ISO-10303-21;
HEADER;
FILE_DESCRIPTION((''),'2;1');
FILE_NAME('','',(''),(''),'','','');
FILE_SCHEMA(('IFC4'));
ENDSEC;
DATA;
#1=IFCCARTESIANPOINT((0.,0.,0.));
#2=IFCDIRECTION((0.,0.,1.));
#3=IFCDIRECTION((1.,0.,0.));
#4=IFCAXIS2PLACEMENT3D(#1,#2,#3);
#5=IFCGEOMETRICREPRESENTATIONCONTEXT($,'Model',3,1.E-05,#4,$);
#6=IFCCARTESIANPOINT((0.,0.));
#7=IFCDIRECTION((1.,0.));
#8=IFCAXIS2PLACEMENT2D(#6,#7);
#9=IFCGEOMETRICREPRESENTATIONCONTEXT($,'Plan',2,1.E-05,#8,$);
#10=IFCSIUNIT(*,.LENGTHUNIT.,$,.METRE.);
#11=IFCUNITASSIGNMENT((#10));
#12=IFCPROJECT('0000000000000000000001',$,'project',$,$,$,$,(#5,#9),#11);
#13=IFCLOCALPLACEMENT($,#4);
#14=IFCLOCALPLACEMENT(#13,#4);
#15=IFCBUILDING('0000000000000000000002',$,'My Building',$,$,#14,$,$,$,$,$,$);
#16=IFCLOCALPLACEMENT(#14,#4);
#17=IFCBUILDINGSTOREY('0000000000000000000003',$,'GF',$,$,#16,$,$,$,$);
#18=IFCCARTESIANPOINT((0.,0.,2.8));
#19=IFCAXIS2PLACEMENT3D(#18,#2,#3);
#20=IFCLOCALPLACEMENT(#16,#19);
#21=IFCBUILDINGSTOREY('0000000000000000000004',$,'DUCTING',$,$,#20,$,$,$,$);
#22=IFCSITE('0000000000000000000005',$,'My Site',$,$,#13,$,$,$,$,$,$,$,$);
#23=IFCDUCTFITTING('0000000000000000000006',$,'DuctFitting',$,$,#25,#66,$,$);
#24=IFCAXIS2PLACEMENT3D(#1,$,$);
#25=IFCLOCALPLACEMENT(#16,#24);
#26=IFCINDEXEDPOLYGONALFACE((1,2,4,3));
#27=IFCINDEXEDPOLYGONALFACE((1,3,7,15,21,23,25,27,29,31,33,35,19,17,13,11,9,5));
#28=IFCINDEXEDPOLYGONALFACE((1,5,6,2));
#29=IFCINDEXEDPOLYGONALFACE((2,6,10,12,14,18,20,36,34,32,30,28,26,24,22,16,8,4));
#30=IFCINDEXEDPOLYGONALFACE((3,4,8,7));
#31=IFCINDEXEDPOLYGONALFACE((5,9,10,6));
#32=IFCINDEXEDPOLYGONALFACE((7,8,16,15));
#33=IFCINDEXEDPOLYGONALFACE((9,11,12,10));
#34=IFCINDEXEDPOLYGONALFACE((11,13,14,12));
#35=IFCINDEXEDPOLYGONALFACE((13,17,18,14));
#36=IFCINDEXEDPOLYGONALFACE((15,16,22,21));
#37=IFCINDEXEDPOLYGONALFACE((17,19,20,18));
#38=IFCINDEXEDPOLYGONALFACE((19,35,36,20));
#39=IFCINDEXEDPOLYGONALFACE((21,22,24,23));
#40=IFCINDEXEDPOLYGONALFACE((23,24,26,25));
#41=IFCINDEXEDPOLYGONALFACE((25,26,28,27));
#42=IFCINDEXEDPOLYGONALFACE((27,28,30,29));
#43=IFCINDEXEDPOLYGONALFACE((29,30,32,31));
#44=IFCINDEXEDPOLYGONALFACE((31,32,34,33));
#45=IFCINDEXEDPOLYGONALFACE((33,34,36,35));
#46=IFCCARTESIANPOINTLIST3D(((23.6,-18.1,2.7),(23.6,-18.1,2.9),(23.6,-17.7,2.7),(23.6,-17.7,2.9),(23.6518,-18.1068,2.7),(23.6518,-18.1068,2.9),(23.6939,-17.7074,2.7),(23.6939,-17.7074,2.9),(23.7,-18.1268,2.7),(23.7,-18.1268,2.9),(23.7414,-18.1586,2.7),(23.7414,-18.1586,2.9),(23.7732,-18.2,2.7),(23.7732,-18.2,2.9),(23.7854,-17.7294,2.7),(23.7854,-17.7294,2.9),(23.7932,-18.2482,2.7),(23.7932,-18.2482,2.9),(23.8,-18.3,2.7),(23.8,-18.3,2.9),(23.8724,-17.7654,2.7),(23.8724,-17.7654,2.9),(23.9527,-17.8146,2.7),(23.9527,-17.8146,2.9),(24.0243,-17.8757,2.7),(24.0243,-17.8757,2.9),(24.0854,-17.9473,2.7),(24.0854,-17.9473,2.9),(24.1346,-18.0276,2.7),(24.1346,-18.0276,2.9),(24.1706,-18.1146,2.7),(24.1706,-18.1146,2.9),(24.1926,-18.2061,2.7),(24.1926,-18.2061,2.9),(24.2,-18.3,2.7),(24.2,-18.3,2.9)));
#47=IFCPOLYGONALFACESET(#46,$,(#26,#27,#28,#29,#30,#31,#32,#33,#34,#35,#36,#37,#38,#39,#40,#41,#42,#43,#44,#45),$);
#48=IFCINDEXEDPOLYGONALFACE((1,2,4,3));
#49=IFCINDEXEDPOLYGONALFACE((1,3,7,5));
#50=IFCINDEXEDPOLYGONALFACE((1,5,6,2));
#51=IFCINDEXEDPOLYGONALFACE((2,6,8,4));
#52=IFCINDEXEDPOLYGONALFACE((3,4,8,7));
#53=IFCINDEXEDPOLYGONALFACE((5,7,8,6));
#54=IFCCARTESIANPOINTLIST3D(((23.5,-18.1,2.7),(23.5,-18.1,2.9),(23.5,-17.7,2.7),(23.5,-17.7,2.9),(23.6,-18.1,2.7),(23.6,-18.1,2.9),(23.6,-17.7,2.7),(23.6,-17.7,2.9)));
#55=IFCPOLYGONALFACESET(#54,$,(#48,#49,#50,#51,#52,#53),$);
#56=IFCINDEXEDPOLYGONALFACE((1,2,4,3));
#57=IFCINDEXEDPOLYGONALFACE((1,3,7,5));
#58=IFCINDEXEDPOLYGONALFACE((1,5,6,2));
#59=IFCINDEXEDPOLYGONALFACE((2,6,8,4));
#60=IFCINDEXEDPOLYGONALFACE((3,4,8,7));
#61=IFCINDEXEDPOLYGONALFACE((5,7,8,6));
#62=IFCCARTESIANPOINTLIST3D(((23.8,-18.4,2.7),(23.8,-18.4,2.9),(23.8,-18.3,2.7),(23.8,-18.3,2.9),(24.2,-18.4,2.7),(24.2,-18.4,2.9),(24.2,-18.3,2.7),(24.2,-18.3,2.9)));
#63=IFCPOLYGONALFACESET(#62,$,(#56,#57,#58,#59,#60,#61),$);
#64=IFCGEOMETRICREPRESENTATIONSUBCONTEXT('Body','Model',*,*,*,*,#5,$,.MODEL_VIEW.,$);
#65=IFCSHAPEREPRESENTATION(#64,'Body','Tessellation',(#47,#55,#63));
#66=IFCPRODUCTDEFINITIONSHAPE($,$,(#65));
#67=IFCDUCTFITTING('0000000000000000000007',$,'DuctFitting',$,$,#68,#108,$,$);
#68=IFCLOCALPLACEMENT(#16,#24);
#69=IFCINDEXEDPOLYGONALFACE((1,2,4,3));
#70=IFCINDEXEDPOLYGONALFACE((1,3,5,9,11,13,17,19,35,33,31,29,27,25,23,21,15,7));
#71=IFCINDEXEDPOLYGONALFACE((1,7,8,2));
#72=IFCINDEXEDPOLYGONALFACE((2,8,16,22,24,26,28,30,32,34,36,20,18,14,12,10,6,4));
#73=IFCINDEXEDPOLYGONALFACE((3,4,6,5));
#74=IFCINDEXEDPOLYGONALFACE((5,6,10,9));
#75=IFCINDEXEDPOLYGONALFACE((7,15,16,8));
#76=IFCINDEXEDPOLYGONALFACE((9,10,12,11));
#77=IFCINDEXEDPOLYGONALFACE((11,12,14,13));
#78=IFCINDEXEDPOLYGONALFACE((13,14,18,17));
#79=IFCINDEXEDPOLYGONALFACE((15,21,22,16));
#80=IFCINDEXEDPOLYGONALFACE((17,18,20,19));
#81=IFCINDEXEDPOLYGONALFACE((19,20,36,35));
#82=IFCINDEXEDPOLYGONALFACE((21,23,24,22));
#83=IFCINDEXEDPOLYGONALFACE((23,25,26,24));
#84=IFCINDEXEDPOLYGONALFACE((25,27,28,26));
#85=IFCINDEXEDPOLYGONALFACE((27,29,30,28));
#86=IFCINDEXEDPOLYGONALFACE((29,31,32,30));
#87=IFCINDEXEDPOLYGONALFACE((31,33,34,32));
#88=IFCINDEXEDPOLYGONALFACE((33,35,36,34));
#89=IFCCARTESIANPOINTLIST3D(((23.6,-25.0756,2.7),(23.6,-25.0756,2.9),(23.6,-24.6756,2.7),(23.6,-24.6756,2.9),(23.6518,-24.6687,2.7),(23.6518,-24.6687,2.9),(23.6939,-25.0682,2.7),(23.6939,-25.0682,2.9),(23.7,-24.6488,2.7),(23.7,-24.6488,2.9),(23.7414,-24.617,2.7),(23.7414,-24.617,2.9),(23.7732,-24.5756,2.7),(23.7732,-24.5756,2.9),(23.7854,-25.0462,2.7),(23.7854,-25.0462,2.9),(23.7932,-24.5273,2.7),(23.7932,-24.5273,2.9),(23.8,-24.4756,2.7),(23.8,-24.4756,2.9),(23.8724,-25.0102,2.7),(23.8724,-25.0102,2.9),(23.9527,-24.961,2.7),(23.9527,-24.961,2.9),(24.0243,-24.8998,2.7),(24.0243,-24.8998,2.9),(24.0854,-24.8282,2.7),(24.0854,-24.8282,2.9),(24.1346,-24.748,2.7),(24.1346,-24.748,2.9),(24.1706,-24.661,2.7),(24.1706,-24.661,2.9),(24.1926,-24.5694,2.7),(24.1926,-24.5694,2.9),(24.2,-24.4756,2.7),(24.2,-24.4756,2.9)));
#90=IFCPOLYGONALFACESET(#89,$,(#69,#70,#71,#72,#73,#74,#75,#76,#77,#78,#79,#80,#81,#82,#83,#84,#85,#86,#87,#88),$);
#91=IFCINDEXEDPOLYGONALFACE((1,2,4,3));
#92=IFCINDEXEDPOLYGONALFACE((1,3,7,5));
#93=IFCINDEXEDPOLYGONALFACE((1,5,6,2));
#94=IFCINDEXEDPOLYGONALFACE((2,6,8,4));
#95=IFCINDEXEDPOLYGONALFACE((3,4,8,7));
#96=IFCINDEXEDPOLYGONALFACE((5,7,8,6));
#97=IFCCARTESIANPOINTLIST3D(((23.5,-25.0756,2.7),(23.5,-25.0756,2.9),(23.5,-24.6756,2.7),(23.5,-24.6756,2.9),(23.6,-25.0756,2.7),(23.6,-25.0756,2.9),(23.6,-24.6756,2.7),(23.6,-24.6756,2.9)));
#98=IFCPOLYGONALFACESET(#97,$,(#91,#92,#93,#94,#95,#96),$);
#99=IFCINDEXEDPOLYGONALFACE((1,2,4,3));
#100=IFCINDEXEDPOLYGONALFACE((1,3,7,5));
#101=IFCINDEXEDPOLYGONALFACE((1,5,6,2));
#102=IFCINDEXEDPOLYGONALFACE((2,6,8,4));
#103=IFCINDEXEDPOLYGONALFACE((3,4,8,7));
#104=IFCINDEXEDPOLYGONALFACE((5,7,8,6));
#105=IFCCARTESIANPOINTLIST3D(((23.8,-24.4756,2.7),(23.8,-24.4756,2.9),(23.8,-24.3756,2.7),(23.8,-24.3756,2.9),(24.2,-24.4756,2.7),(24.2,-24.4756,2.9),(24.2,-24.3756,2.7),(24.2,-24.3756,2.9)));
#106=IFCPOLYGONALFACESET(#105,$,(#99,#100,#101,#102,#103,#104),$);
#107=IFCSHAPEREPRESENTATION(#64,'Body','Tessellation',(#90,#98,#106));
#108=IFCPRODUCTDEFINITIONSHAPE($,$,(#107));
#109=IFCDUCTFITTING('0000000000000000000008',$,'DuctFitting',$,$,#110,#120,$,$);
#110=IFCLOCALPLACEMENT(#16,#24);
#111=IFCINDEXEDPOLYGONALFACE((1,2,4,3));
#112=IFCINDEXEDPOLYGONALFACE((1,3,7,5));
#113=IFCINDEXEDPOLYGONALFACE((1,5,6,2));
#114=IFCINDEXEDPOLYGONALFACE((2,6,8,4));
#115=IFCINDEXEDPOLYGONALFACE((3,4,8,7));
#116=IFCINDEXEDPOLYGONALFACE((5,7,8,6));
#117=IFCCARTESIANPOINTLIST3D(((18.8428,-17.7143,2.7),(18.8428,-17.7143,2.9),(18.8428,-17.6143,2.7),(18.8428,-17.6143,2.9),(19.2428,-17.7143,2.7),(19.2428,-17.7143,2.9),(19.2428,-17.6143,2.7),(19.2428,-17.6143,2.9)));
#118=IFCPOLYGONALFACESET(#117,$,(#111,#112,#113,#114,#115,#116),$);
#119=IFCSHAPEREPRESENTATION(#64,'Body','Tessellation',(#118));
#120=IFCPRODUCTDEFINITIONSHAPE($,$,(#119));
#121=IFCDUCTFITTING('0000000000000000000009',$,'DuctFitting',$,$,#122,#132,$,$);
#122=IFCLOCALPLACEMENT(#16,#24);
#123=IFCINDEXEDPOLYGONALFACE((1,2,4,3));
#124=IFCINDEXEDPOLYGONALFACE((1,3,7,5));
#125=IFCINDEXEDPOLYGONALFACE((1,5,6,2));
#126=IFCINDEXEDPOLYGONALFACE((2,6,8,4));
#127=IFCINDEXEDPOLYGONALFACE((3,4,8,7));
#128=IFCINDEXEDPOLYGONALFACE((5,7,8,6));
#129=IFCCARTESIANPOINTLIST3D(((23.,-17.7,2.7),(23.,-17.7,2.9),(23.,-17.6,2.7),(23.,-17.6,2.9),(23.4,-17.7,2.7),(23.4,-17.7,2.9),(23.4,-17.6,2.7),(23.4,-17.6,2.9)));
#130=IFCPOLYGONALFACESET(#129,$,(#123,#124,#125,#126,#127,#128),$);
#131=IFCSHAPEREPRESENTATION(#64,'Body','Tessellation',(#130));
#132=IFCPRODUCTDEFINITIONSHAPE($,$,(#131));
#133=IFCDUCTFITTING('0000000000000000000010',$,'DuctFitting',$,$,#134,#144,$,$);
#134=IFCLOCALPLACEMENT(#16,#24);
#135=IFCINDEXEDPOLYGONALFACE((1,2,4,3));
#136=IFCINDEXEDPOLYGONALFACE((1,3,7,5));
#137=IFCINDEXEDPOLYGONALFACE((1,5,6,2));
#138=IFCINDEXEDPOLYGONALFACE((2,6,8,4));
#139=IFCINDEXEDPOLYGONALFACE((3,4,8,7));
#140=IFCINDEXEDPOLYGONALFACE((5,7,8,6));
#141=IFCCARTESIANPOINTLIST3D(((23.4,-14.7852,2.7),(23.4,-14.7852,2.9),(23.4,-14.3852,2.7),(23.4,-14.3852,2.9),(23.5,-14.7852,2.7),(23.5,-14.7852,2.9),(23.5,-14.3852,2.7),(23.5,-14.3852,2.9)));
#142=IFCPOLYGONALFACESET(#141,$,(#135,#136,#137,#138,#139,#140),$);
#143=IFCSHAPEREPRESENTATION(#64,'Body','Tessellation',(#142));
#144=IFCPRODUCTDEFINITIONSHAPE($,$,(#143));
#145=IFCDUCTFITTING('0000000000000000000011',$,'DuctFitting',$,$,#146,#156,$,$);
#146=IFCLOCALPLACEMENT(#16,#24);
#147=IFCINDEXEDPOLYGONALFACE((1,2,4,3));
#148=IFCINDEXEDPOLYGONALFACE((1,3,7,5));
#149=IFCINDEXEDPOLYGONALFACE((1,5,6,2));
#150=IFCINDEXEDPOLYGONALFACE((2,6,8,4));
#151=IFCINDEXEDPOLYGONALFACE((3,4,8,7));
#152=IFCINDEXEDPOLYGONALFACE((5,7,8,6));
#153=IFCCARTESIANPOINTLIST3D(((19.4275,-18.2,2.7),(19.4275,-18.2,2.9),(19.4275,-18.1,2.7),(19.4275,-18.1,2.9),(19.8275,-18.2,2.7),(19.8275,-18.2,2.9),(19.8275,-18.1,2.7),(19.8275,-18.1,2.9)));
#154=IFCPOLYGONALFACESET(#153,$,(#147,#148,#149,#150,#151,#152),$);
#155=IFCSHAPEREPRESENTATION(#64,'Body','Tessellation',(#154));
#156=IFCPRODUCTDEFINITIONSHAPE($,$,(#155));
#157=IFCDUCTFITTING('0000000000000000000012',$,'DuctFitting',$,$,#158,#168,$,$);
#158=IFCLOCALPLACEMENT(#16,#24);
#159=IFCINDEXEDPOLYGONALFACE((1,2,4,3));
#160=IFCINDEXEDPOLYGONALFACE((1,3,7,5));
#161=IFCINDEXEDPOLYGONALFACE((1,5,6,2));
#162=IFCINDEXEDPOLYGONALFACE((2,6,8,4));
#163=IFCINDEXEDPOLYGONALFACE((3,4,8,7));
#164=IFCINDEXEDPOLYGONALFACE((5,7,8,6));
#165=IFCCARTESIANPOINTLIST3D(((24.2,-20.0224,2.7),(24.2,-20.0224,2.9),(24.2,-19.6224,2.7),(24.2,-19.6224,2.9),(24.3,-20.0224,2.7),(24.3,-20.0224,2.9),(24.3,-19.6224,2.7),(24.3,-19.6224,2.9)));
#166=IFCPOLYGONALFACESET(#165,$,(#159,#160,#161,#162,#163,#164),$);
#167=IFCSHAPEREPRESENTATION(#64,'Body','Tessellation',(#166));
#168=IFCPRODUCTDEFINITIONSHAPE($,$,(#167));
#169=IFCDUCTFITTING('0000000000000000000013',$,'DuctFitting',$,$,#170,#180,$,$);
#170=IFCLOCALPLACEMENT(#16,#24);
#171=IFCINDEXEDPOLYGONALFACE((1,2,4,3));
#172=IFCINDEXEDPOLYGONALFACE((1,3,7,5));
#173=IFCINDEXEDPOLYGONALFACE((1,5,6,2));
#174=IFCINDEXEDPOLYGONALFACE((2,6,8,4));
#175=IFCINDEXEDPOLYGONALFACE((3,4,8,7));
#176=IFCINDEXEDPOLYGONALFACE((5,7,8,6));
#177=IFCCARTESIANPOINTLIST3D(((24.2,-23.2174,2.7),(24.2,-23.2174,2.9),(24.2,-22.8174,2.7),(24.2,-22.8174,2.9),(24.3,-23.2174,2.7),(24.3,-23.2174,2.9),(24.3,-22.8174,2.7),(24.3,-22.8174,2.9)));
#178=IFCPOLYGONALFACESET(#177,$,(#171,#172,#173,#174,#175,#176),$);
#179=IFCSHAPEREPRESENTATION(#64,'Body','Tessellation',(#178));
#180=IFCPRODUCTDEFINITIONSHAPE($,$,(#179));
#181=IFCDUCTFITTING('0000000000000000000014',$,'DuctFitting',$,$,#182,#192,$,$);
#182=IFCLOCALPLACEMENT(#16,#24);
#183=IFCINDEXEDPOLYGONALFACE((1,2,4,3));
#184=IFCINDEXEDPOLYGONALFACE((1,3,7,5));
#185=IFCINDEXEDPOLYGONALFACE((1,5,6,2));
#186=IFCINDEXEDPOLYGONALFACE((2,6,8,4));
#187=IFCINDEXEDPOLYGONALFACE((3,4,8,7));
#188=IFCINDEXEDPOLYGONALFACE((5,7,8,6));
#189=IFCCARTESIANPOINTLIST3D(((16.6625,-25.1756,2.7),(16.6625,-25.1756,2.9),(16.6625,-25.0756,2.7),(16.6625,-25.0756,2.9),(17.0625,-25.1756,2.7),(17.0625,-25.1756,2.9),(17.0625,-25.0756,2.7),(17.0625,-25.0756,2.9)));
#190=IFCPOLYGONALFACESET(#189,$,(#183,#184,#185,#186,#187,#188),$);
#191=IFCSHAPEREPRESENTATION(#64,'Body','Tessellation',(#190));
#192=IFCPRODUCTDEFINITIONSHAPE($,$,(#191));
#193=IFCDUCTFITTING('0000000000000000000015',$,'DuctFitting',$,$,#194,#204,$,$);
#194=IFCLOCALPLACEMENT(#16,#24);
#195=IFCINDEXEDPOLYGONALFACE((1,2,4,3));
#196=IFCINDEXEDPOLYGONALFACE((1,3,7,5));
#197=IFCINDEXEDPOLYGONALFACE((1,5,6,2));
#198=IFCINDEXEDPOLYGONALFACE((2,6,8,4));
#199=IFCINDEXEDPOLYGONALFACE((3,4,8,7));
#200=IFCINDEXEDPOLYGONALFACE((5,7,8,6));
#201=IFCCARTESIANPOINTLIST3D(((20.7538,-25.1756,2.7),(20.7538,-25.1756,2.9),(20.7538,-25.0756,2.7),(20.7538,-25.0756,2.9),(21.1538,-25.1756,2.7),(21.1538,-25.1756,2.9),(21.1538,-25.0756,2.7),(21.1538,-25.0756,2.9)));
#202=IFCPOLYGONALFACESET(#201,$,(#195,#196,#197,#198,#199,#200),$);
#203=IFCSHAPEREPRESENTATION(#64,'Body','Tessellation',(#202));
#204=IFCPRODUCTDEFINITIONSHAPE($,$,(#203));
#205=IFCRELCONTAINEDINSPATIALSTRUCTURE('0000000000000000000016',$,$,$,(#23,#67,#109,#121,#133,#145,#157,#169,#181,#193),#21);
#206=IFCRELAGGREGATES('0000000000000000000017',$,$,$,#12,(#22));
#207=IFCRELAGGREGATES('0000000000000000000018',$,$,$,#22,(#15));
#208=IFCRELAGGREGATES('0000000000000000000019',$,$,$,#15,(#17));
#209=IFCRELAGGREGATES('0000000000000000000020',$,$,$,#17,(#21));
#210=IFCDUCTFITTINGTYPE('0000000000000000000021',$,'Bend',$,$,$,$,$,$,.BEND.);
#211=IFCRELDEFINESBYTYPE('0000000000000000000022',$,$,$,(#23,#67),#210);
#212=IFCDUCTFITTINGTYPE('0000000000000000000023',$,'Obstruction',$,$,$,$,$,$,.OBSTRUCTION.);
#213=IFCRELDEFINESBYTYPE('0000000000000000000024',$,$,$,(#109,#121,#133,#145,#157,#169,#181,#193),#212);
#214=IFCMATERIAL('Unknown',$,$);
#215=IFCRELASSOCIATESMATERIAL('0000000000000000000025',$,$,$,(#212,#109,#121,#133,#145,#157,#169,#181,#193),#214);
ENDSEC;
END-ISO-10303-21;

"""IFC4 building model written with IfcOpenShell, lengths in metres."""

from ifc_helpers import new_model, si_unit, frame, origin_with_axes, origin_2d_with_axis, place, context, subcontext, project, spatial, line, arc, indexed_curve, rectangle, outline, extrude, source, transform, mapped, material, material_profile, profile_set, profile_usage, type_object, type_shapes, element, save


model = new_model("IFC4")

# Units and contexts
model_context = context("Model", 3, precision=1e-05, world=origin_with_axes())
plan_context = context("Plan", 2, precision=1e-05, world=origin_2d_with_axis())
body_context = subcontext(model_context, "Body", "Model", "MODEL_VIEW")
ifc_project = project(units=[si_unit("LENGTHUNIT", "METRE")], contexts=[model_context, plan_context])

# Site, building, storeys
site_placement = place(None, origin_with_axes())
site = spatial("IfcSite", under=ifc_project, at=site_placement, Name="My Site")
building_placement = place(site_placement, origin_with_axes())
building = spatial("IfcBuilding", under=site, at=building_placement, Name="My Building")
storey_1_placement = place(building_placement, origin_with_axes())
storey_1 = spatial("IfcBuildingStorey", under=building, at=storey_1_placement, Name="GF")
storey_2_placement = place(storey_1_placement, frame((0.0, 0.0, 2.8), z_axis=(0.0, 0.0, 1.0), x_axis=(1.0, 0.0, 0.0)))
storey_2 = spatial("IfcBuildingStorey", under=storey_1, at=storey_2_placement, Name="DUCTING")

# Shared definitions
ifc_material = material(Name="Unknown")

# Duct fittings
duct_fitting_type_1 = type_object("IfcDuctFittingType", Name="Bend", PredefinedType="BEND")
shared_shape = source(origin_with_axes(), body_context, "Body", "SweptSolid", [
    extrude(outline(indexed_curve([(0.2, 0.0), (0.2586, -0.1414), (0.4, -0.2), (0.4, -0.6), (-0.0243, -0.4243), (-0.2, 0.0)], segments=[arc(1, 2, 3), line(3, 4), arc(4, 5, 6), line(6, 1)])), frame((0.0, -0.1, -0.1), z_axis=(0.0, -1.0, 0.0), x_axis=(1.0, 0.0, 0.0)), (0.0, 0.0, -1.0), 0.2),
    extrude(rectangle(XDim=0.4, YDim=0.2), origin_with_axes(), (0.0, 0.0, -1.0), 0.1),
    extrude(rectangle(XDim=0.4, YDim=0.2), frame((0.4, 0.0, -0.5), z_axis=(1.0, 0.0, 0.0), x_axis=(0.0, 0.0, 1.0)), (0.0, 0.0, 1.0), 0.1),
])
type_shapes(duct_fitting_type_1, [shared_shape])
for number, where, z_axis, x_axis, name in (
    (1, (23.5, -17.9, 0.0), (-1.0, 0.0, 0.0), (0.0, -1.0, 0.0), "DuctFitting"),
    (2, (23.5, -24.8756, 0.0), (-1.0, 0.0, 0.0), (0.0, 1.0, 0.0), "DuctFitting"),
):
    element("IfcDuctFitting", number, at=place(storey_2_placement, frame(where, z_axis=z_axis, x_axis=x_axis)), inside=storey_2, type_object=duct_fitting_type_1, Name=name, context=body_context, shape_type="MappedRepresentation", body=[
        mapped(shared_shape, transform((0.0, 0.0, 0.0), x_axis=(1.0, 0.0, 0.0), y_axis=(0.0, 1.0, 0.0), z_axis=(0.0, 0.0, 1.0), scale=1.0)),
    ])
ifc_material_profile_1 = material_profile(ifc_material, rectangle(XDim=0.4, YDim=0.2))
ifc_profile_set_1 = profile_set([ifc_material_profile_1])
ifc_profile_usage_1 = profile_usage(ifc_profile_set_1, cardinal=5)
duct_fitting_type_2 = type_object("IfcDuctFittingType", Name="Obstruction", PredefinedType="OBSTRUCTION", material=ifc_profile_set_1)
duct_fitting_1_placement = place(storey_2_placement, frame((19.0428, -17.7143, 0.0), z_axis=(0.0, 1.0, 0.0), x_axis=(-1.0, 0.0, 0.0)))
element("IfcDuctFitting", 3, at=duct_fitting_1_placement, inside=storey_2, type_object=duct_fitting_type_2, material=ifc_profile_usage_1, Name="DuctFitting", context=body_context, shape_type="SweptSolid", body=[
    extrude(rectangle(XDim=0.4, YDim=0.2), origin_with_axes(), (0.0, 0.0, 1.0), 0.1),
])
ifc_profile_usage_2 = profile_usage(ifc_profile_set_1, cardinal=5)
duct_fitting_2_placement = place(storey_2_placement, frame((23.2, -17.7, 0.0), z_axis=(0.0, 1.0, 0.0), x_axis=(-1.0, 0.0, 0.0)))
element("IfcDuctFitting", 4, at=duct_fitting_2_placement, inside=storey_2, type_object=duct_fitting_type_2, material=ifc_profile_usage_2, Name="DuctFitting", context=body_context, shape_type="SweptSolid", body=[
    extrude(rectangle(XDim=0.4, YDim=0.2), origin_with_axes(), (0.0, 0.0, 1.0), 0.1),
])
ifc_profile_usage_3 = profile_usage(ifc_profile_set_1, cardinal=5)
duct_fitting_3_placement = place(storey_2_placement, frame((23.4, -14.5852, 0.0), z_axis=(1.0, 0.0, 0.0), x_axis=(0.0, 1.0, 0.0)))
element("IfcDuctFitting", 5, at=duct_fitting_3_placement, inside=storey_2, type_object=duct_fitting_type_2, material=ifc_profile_usage_3, Name="DuctFitting", context=body_context, shape_type="SweptSolid", body=[
    extrude(rectangle(XDim=0.4, YDim=0.2), origin_with_axes(), (0.0, 0.0, 1.0), 0.1),
])
ifc_profile_usage_4 = profile_usage(ifc_profile_set_1, cardinal=5)
duct_fitting_4_placement = place(storey_2_placement, frame((19.6275, -18.2, 0.0), z_axis=(0.0, 1.0, 0.0), x_axis=(-1.0, 0.0, 0.0)))
element("IfcDuctFitting", 6, at=duct_fitting_4_placement, inside=storey_2, type_object=duct_fitting_type_2, material=ifc_profile_usage_4, Name="DuctFitting", context=body_context, shape_type="SweptSolid", body=[
    extrude(rectangle(XDim=0.4, YDim=0.2), origin_with_axes(), (0.0, 0.0, 1.0), 0.1),
])
ifc_profile_usage_5 = profile_usage(ifc_profile_set_1, cardinal=5)
duct_fitting_5_placement = place(storey_2_placement, frame((24.2, -19.8224, 0.0), z_axis=(1.0, 0.0, 0.0), x_axis=(0.0, 1.0, 0.0)))
element("IfcDuctFitting", 7, at=duct_fitting_5_placement, inside=storey_2, type_object=duct_fitting_type_2, material=ifc_profile_usage_5, Name="DuctFitting", context=body_context, shape_type="SweptSolid", body=[
    extrude(rectangle(XDim=0.4, YDim=0.2), origin_with_axes(), (0.0, 0.0, 1.0), 0.1),
])
ifc_profile_usage_6 = profile_usage(ifc_profile_set_1, cardinal=5)
duct_fitting_6_placement = place(storey_2_placement, frame((24.2, -23.0174, 0.0), z_axis=(1.0, 0.0, 0.0), x_axis=(0.0, 1.0, 0.0)))
element("IfcDuctFitting", 8, at=duct_fitting_6_placement, inside=storey_2, type_object=duct_fitting_type_2, material=ifc_profile_usage_6, Name="DuctFitting", context=body_context, shape_type="SweptSolid", body=[
    extrude(rectangle(XDim=0.4, YDim=0.2), origin_with_axes(), (0.0, 0.0, 1.0), 0.1),
])
ifc_profile_usage_7 = profile_usage(ifc_profile_set_1, cardinal=5)
duct_fitting_7_placement = place(storey_2_placement, frame((16.8625, -25.1756, 0.0), z_axis=(0.0, 1.0, 0.0), x_axis=(-1.0, 0.0, 0.0)))
element("IfcDuctFitting", 9, at=duct_fitting_7_placement, inside=storey_2, type_object=duct_fitting_type_2, material=ifc_profile_usage_7, Name="DuctFitting", context=body_context, shape_type="SweptSolid", body=[
    extrude(rectangle(XDim=0.4, YDim=0.2), origin_with_axes(), (0.0, 0.0, 1.0), 0.1),
])
ifc_profile_usage_8 = profile_usage(ifc_profile_set_1, cardinal=5)
duct_fitting_8_placement = place(storey_2_placement, frame((20.9538, -25.1756, 0.0), z_axis=(0.0, 1.0, 0.0), x_axis=(-1.0, 0.0, 0.0)))
element("IfcDuctFitting", 10, at=duct_fitting_8_placement, inside=storey_2, type_object=duct_fitting_type_2, material=ifc_profile_usage_8, Name="DuctFitting", context=body_context, shape_type="SweptSolid", body=[
    extrude(rectangle(XDim=0.4, YDim=0.2), origin_with_axes(), (0.0, 0.0, 1.0), 0.1),
])

save(model, "model.ifc")
